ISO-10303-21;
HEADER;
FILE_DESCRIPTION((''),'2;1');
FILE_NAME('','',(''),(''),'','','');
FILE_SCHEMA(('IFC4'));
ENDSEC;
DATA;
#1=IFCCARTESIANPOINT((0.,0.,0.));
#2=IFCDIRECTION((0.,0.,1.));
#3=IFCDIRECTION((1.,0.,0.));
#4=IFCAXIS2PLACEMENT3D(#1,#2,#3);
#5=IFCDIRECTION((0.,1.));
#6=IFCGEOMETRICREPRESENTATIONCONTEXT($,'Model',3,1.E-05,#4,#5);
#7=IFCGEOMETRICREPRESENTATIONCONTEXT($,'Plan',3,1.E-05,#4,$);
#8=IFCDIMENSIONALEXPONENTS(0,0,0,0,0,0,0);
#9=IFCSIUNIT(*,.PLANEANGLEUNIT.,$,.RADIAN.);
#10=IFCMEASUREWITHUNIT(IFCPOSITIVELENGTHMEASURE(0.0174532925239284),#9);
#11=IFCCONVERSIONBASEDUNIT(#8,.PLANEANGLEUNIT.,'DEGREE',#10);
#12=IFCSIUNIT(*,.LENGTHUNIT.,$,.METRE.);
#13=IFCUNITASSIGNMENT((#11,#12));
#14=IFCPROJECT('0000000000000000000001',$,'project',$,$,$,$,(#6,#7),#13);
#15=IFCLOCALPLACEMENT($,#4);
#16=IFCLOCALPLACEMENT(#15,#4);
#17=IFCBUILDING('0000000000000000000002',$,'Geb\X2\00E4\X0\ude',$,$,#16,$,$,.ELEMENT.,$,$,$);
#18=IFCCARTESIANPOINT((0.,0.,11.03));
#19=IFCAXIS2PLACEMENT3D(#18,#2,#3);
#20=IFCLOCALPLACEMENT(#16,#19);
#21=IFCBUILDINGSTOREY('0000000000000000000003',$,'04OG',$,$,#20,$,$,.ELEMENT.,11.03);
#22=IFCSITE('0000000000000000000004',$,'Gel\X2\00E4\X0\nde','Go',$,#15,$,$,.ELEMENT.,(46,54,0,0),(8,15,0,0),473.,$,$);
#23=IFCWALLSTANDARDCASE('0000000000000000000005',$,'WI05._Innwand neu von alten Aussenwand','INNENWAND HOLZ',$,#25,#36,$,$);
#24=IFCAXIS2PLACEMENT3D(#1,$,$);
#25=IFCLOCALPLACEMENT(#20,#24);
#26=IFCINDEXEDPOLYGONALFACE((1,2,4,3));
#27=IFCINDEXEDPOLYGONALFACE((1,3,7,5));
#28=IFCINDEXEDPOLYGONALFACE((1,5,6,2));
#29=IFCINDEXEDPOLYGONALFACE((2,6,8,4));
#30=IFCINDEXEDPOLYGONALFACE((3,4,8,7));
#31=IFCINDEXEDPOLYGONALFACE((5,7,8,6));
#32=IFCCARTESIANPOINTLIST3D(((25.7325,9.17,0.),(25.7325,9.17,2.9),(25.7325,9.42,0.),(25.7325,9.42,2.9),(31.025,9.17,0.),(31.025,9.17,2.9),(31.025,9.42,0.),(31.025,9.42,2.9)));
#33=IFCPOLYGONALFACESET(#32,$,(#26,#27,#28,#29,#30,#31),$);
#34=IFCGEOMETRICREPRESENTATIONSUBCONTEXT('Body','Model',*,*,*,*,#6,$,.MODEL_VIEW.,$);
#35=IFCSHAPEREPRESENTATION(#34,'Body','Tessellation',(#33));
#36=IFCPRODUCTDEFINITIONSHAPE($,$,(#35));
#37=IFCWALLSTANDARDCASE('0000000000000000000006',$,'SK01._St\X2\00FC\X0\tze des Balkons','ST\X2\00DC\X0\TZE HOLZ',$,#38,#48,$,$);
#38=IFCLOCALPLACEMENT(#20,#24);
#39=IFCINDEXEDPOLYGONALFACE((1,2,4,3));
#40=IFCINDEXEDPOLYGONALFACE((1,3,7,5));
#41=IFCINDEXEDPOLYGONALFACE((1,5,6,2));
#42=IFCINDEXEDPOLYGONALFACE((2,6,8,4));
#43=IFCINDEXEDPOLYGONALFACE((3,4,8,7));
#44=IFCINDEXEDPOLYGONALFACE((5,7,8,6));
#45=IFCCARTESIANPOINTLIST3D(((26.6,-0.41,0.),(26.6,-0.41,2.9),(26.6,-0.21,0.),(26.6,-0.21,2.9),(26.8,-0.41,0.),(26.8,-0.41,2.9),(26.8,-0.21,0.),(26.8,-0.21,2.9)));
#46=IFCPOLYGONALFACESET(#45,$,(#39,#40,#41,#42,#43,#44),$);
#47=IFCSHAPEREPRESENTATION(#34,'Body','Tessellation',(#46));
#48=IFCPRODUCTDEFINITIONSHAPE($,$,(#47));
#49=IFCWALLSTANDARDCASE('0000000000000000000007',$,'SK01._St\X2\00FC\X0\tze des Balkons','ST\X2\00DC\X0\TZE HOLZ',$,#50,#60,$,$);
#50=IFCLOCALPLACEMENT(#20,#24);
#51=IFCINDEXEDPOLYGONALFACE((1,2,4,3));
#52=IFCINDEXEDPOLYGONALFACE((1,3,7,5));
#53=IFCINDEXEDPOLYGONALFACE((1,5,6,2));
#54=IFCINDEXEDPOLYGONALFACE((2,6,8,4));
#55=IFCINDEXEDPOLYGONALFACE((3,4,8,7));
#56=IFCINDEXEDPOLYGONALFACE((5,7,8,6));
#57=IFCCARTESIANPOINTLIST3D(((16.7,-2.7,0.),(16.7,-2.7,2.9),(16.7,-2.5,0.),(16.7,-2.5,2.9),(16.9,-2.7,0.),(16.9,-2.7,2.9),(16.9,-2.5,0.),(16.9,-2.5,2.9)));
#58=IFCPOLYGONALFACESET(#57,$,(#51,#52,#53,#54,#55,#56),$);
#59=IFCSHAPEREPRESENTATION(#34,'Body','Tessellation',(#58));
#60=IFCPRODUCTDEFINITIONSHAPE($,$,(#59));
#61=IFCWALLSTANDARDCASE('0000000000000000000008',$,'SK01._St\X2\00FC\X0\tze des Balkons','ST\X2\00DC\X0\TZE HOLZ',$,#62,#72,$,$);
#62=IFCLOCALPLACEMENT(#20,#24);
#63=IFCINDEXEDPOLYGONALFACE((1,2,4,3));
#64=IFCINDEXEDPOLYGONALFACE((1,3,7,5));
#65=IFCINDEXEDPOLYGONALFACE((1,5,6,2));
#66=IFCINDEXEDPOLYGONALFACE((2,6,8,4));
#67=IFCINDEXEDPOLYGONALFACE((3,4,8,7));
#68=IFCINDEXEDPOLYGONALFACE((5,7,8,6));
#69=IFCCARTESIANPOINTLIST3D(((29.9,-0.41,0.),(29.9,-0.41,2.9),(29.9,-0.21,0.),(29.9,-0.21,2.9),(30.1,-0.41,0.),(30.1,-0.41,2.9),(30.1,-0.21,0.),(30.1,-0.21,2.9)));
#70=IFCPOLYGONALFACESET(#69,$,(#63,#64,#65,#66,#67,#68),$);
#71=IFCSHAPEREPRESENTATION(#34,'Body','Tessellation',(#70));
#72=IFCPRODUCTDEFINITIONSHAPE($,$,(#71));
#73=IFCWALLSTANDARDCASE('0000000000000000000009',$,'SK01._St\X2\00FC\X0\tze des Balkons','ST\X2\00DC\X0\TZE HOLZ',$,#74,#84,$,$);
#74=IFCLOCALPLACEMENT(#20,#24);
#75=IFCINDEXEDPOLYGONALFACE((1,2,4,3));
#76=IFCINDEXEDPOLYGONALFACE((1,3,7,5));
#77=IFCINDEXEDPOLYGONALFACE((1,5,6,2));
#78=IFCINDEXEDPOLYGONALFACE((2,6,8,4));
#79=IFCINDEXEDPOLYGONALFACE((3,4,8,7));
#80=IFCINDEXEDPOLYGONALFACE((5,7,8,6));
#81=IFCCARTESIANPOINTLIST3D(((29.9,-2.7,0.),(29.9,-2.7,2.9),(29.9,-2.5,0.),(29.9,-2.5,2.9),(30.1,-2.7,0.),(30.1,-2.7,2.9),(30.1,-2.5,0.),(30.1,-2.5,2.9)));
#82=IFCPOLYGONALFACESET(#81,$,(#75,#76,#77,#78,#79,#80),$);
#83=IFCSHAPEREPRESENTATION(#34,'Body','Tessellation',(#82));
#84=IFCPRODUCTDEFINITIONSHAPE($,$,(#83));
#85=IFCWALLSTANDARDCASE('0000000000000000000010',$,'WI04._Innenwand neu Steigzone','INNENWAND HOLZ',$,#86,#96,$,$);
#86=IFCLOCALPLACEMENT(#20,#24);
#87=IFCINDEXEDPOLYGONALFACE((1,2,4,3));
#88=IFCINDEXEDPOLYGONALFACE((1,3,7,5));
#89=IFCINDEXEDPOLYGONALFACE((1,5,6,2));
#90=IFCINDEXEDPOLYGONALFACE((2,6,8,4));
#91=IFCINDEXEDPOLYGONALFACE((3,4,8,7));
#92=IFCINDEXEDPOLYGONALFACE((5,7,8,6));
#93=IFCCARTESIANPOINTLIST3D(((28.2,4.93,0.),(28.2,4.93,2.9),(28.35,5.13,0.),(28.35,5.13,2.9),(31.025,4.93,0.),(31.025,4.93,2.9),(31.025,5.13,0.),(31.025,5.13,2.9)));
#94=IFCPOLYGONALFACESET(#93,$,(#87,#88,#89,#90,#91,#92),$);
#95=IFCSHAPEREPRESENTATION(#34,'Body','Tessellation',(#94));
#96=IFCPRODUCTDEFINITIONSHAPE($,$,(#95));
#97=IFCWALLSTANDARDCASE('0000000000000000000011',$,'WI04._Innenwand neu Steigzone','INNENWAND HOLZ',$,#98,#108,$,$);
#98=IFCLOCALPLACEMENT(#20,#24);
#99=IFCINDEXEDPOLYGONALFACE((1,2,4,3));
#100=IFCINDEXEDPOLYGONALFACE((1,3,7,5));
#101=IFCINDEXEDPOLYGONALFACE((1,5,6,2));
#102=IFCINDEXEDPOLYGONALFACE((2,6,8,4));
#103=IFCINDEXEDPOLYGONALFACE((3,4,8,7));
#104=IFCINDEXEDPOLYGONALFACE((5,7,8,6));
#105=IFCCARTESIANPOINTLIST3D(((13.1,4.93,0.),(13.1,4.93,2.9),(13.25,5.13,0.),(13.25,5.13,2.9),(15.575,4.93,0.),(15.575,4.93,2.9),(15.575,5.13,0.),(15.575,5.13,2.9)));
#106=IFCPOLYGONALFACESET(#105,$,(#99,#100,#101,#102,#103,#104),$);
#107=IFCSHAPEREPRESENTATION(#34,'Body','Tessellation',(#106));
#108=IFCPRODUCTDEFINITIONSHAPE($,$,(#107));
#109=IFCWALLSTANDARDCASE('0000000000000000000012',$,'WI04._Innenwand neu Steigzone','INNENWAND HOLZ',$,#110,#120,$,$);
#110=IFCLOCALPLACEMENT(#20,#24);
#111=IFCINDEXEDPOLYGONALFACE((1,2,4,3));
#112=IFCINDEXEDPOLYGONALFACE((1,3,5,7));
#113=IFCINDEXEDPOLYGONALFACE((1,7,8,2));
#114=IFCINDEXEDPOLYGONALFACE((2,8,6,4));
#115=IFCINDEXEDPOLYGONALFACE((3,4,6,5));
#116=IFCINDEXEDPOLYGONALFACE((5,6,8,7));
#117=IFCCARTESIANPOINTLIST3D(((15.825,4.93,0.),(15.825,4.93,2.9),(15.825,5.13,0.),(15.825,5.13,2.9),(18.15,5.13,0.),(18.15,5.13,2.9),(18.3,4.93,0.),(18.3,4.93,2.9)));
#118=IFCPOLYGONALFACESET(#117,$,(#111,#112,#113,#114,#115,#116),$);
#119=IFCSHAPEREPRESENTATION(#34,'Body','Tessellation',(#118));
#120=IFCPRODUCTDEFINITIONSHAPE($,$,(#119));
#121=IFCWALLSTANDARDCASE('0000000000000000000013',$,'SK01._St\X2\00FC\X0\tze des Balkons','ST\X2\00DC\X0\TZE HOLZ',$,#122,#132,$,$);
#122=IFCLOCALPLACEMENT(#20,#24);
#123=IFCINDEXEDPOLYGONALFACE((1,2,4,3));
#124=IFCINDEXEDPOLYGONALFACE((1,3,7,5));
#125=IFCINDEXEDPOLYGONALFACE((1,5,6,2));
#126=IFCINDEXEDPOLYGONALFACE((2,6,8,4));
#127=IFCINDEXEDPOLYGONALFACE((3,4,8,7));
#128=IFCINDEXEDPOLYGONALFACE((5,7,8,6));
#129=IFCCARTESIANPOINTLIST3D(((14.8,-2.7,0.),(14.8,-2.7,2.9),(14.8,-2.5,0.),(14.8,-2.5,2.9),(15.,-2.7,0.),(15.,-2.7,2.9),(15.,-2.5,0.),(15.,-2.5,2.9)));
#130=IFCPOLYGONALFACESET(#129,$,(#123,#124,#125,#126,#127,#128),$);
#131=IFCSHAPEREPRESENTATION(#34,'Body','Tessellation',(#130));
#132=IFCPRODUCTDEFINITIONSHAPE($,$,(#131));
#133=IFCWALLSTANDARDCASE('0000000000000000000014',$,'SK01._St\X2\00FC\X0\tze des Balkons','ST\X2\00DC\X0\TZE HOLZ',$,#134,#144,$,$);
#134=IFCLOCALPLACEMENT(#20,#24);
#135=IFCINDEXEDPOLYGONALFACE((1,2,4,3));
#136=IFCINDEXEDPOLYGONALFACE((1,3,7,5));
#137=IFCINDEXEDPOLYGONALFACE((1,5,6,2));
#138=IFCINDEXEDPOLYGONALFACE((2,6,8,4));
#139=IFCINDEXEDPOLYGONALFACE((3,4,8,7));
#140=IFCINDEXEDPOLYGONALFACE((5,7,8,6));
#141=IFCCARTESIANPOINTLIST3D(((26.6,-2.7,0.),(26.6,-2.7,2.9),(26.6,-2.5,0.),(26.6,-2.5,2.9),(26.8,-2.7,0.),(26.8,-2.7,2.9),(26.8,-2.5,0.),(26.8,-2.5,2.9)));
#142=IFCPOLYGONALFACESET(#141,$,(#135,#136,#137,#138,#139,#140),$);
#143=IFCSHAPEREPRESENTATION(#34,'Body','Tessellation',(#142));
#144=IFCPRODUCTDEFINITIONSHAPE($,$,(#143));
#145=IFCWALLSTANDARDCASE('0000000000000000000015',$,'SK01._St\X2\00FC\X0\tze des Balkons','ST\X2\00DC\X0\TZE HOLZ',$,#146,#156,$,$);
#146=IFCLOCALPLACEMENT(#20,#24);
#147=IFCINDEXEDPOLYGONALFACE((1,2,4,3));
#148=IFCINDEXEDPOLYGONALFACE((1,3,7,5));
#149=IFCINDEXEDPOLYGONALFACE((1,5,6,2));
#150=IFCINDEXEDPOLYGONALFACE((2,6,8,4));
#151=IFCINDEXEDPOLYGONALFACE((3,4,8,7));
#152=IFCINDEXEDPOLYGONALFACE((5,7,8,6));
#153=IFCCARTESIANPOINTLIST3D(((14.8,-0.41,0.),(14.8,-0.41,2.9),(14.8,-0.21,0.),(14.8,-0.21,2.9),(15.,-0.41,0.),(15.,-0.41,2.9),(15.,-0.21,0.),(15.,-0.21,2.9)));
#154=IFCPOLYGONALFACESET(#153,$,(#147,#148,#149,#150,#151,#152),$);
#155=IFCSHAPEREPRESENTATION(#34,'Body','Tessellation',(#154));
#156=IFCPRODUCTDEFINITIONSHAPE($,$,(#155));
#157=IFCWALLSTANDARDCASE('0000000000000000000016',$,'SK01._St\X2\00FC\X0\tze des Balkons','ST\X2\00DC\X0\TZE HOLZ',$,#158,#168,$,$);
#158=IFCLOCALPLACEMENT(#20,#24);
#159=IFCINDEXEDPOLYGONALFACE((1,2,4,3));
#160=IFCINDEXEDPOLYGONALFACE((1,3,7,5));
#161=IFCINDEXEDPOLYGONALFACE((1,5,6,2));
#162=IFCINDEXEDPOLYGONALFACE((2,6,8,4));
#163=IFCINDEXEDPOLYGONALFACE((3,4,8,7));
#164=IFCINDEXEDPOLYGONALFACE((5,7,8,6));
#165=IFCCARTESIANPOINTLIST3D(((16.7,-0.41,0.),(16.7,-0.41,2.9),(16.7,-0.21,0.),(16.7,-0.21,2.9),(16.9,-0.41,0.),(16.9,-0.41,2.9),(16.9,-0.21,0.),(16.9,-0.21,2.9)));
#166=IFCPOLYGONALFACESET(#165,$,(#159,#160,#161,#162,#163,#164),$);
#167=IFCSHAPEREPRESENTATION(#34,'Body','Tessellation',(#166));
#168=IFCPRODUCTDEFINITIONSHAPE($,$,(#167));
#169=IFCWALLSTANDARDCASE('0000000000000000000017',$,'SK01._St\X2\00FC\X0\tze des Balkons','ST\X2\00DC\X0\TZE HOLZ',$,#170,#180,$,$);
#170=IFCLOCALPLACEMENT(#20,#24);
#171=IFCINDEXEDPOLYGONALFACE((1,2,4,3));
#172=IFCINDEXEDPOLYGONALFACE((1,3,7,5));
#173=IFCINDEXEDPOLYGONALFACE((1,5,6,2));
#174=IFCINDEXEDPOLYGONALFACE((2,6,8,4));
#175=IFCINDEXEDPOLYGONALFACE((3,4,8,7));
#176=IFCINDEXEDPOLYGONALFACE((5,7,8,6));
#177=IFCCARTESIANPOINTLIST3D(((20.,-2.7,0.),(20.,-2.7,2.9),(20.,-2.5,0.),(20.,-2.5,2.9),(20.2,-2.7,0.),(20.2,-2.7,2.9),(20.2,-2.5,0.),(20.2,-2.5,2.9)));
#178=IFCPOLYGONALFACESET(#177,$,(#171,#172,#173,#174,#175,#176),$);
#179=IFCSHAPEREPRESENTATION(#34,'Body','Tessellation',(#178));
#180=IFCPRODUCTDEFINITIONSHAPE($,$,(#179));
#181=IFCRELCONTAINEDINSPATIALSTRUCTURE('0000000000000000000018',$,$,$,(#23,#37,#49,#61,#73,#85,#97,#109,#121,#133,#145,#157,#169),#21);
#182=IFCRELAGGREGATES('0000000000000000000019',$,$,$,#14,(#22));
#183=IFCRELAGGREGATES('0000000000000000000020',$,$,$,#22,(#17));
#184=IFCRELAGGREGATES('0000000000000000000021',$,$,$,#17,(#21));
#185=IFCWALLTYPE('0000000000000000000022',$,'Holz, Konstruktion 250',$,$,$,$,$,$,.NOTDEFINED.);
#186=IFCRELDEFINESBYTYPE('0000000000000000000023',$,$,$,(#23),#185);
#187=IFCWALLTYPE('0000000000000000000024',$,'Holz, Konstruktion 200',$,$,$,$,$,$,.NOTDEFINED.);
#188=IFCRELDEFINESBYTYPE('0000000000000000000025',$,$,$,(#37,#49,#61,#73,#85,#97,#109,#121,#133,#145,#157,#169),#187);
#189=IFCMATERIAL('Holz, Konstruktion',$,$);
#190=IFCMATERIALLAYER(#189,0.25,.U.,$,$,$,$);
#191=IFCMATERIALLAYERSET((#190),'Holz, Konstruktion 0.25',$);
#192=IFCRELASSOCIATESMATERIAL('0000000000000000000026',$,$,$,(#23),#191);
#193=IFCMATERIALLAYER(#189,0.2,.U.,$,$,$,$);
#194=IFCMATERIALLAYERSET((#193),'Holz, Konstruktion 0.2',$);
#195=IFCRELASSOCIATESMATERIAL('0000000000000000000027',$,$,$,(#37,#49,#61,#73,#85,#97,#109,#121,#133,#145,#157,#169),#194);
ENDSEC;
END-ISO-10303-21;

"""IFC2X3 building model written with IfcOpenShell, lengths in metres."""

from ifc_helpers import new_model, entity, si_unit, converted_unit, direction, frame, origin_with_axes, place, context, subcontext, project, spatial, polyline, outline, extrude, material, layer, layer_set, layer_usage, type_object, element, save


model = new_model("IFC2X3")

# Units and contexts
model_context = context("Model", 3, precision=1e-05, world=origin_with_axes(), true_north=direction((0.0, 1.0)))
plan_context = context("Plan", 3, precision=1e-05, world=origin_with_axes())
body_context = subcontext(model_context, "Body", "Model", "MODEL_VIEW")
ifc_project = project(units=[converted_unit("PLANEANGLEUNIT", "DEGREE", entity("IfcPositiveLengthMeasure", 0.0174532925239284), si_unit("PLANEANGLEUNIT", "RADIAN"), dimensions=[0, 0, 0, 0, 0, 0, 0]), si_unit("LENGTHUNIT", "METRE")], contexts=[model_context, plan_context])

# Site, building, storey
site_placement = place(None, origin_with_axes())
site = spatial("IfcSite", under=ifc_project, at=site_placement, Name="Gelände", Description="Go", CompositionType="ELEMENT", RefLatitude=(46, 54, 0, 0), RefLongitude=(8, 15, 0, 0), RefElevation=473.0)
building_placement = place(site_placement, origin_with_axes())
building = spatial("IfcBuilding", under=site, at=building_placement, Name="Gebäude", CompositionType="ELEMENT")
storey_placement = place(building_placement, frame((0.0, 0.0, 11.03), z_axis=(0.0, 0.0, 1.0), x_axis=(1.0, 0.0, 0.0)))
storey = spatial("IfcBuildingStorey", under=building, at=storey_placement, Name="04OG", CompositionType="ELEMENT", Elevation=11.03)

# Shared definitions
ifc_material_1 = material(Name="Holz, Konstruktion")

# Walls
ifc_layer_1 = layer(ifc_material_1, 0.25, ventilated="UNKNOWN")
ifc_layer_set_1 = layer_set([ifc_layer_1], Name="Holz, Konstruktion 0.25")
wall_type_1 = type_object("IfcWallType", Name="Holz, Konstruktion 250", PredefinedType="NOTDEFINED")
ifc_layer_usage_1 = layer_usage(ifc_layer_set_1, "AXIS2", "NEGATIVE", 0.0)
wall_1_placement = place(storey_placement, frame((25.7325, 9.42, 0.0), z_axis=(0.0, 0.0, 1.0), x_axis=(1.0, 0.0, 0.0)))
element("IfcWallStandardCase", 1, at=wall_1_placement, inside=storey, type_object=wall_type_1, material=ifc_layer_usage_1, Name="WI05._Innwand neu von alten Aussenwand", Description="INNENWAND HOLZ", context=body_context, shape_type="SweptSolid", body=[
    extrude(outline(polyline([(0.0, -0.25), (5.2925, -0.25), (5.2925, 0.0), (0.0, 0.0), (0.0, -0.25)])), origin_with_axes(), (0.0, 0.0, 1.0), 2.9),
])
ifc_layer_2 = layer(ifc_material_1, 0.2, ventilated="UNKNOWN")
ifc_layer_set_2 = layer_set([ifc_layer_2], Name="Holz, Konstruktion 0.2")
ifc_layer_usage_2 = layer_usage(ifc_layer_set_2, "AXIS2", "NEGATIVE", 0.0)
wall_type_2 = type_object("IfcWallType", Name="Holz, Konstruktion 200", PredefinedType="NOTDEFINED")
wall_2_placement = place(storey_placement, frame((26.6, -0.41, 0.0), z_axis=(0.0, 0.0, 1.0), x_axis=(0.0, 1.0, 0.0)))
element("IfcWallStandardCase", 2, at=wall_2_placement, inside=storey, type_object=wall_type_2, material=ifc_layer_usage_2, Name="SK01._Stütze des Balkons", Description="STÜTZE HOLZ", context=body_context, shape_type="SweptSolid", body=[
    extrude(outline(polyline([(0.0, -0.2), (0.2, -0.2), (0.2, 0.0), (0.0, 0.0), (0.0, -0.2)])), origin_with_axes(), (0.0, 0.0, 1.0), 2.9),
])
ifc_layer_usage_3 = layer_usage(ifc_layer_set_2, "AXIS2", "NEGATIVE", 0.0)
wall_3_placement = place(storey_placement, frame((16.7, -2.7, 0.0), z_axis=(0.0, 0.0, 1.0), x_axis=(0.0, 1.0, 0.0)))
element("IfcWallStandardCase", 3, at=wall_3_placement, inside=storey, type_object=wall_type_2, material=ifc_layer_usage_3, Name="SK01._Stütze des Balkons", Description="STÜTZE HOLZ", context=body_context, shape_type="SweptSolid", body=[
    extrude(outline(polyline([(0.0, -0.2), (0.2, -0.2), (0.2, 0.0), (0.0, 0.0), (0.0, -0.2)])), origin_with_axes(), (0.0, 0.0, 1.0), 2.9),
])
ifc_layer_usage_4 = layer_usage(ifc_layer_set_2, "AXIS2", "POSITIVE", 0.0)
wall_4_placement = place(storey_placement, frame((30.1, -0.41, 0.0), z_axis=(0.0, 0.0, 1.0), x_axis=(0.0, 1.0, 0.0)))
element("IfcWallStandardCase", 4, at=wall_4_placement, inside=storey, type_object=wall_type_2, material=ifc_layer_usage_4, Name="SK01._Stütze des Balkons", Description="STÜTZE HOLZ", context=body_context, shape_type="SweptSolid", body=[
    extrude(outline(polyline([(0.0, 0.0), (0.2, 0.0), (0.2, 0.2), (0.0, 0.2), (0.0, 0.0)])), origin_with_axes(), (0.0, 0.0, 1.0), 2.9),
])
ifc_layer_usage_5 = layer_usage(ifc_layer_set_2, "AXIS2", "POSITIVE", 0.0)
wall_5_placement = place(storey_placement, frame((30.1, -2.7, 0.0), z_axis=(0.0, 0.0, 1.0), x_axis=(0.0, 1.0, 0.0)))
element("IfcWallStandardCase", 5, at=wall_5_placement, inside=storey, type_object=wall_type_2, material=ifc_layer_usage_5, Name="SK01._Stütze des Balkons", Description="STÜTZE HOLZ", context=body_context, shape_type="SweptSolid", body=[
    extrude(outline(polyline([(0.0, 0.0), (0.2, 0.0), (0.2, 0.2), (0.0, 0.2), (0.0, 0.0)])), origin_with_axes(), (0.0, 0.0, 1.0), 2.9),
])
ifc_layer_usage_6 = layer_usage(ifc_layer_set_2, "AXIS2", "POSITIVE", 0.0)
wall_6_placement = place(storey_placement, frame((28.2, 4.93, 0.0), z_axis=(0.0, 0.0, 1.0), x_axis=(1.0, 0.0, 0.0)))
element("IfcWallStandardCase", 6, at=wall_6_placement, inside=storey, type_object=wall_type_2, material=ifc_layer_usage_6, Name="WI04._Innenwand neu Steigzone", Description="INNENWAND HOLZ", context=body_context, shape_type="SweptSolid", body=[
    extrude(outline(polyline([(0.0, 0.0), (2.825, 0.0), (2.825, 0.2), (0.15, 0.2), (0.0, 0.0)])), origin_with_axes(), (0.0, 0.0, 1.0), 2.9),
])
ifc_layer_usage_7 = layer_usage(ifc_layer_set_2, "AXIS2", "POSITIVE", 0.0)
wall_7_placement = place(storey_placement, frame((13.1, 4.93, 0.0), z_axis=(0.0, 0.0, 1.0), x_axis=(1.0, 0.0, 0.0)))
element("IfcWallStandardCase", 7, at=wall_7_placement, inside=storey, type_object=wall_type_2, material=ifc_layer_usage_7, Name="WI04._Innenwand neu Steigzone", Description="INNENWAND HOLZ", context=body_context, shape_type="SweptSolid", body=[
    extrude(outline(polyline([(0.0, 0.0), (2.475, 0.0), (2.475, 0.2), (0.15, 0.2), (0.0, 0.0)])), origin_with_axes(), (0.0, 0.0, 1.0), 2.9),
])
ifc_layer_usage_8 = layer_usage(ifc_layer_set_2, "AXIS2", "NEGATIVE", 0.0)
wall_8_placement = place(storey_placement, frame((18.3, 4.93, 0.0), z_axis=(0.0, 0.0, 1.0), x_axis=(-1.0, 0.0, 0.0)))
element("IfcWallStandardCase", 8, at=wall_8_placement, inside=storey, type_object=wall_type_2, material=ifc_layer_usage_8, Name="WI04._Innenwand neu Steigzone", Description="INNENWAND HOLZ", context=body_context, shape_type="SweptSolid", body=[
    extrude(outline(polyline([(0.15, -0.2), (2.475, -0.2), (2.475, 0.0), (0.0, 0.0), (0.15, -0.2)])), origin_with_axes(), (0.0, 0.0, 1.0), 2.9),
])
ifc_layer_usage_9 = layer_usage(ifc_layer_set_2, "AXIS2", "POSITIVE", 0.0)
wall_9_placement = place(storey_placement, frame((15.0, -2.7, 0.0), z_axis=(0.0, 0.0, 1.0), x_axis=(0.0, 1.0, 0.0)))
element("IfcWallStandardCase", 9, at=wall_9_placement, inside=storey, type_object=wall_type_2, material=ifc_layer_usage_9, Name="SK01._Stütze des Balkons", Description="STÜTZE HOLZ", context=body_context, shape_type="SweptSolid", body=[
    extrude(outline(polyline([(0.0, 0.0), (0.2, 0.0), (0.2, 0.2), (0.0, 0.2), (0.0, 0.0)])), origin_with_axes(), (0.0, 0.0, 1.0), 2.9),
])
ifc_layer_usage_10 = layer_usage(ifc_layer_set_2, "AXIS2", "NEGATIVE", 0.0)
wall_10_placement = place(storey_placement, frame((26.6, -2.7, 0.0), z_axis=(0.0, 0.0, 1.0), x_axis=(0.0, 1.0, 0.0)))
element("IfcWallStandardCase", 10, at=wall_10_placement, inside=storey, type_object=wall_type_2, material=ifc_layer_usage_10, Name="SK01._Stütze des Balkons", Description="STÜTZE HOLZ", context=body_context, shape_type="SweptSolid", body=[
    extrude(outline(polyline([(0.0, -0.2), (0.2, -0.2), (0.2, 0.0), (0.0, 0.0), (0.0, -0.2)])), origin_with_axes(), (0.0, 0.0, 1.0), 2.9),
])
ifc_layer_usage_11 = layer_usage(ifc_layer_set_2, "AXIS2", "POSITIVE", 0.0)
wall_11_placement = place(storey_placement, frame((15.0, -0.41, 0.0), z_axis=(0.0, 0.0, 1.0), x_axis=(0.0, 1.0, 0.0)))
element("IfcWallStandardCase", 11, at=wall_11_placement, inside=storey, type_object=wall_type_2, material=ifc_layer_usage_11, Name="SK01._Stütze des Balkons", Description="STÜTZE HOLZ", context=body_context, shape_type="SweptSolid", body=[
    extrude(outline(polyline([(0.0, 0.0), (0.2, 0.0), (0.2, 0.2), (0.0, 0.2), (0.0, 0.0)])), origin_with_axes(), (0.0, 0.0, 1.0), 2.9),
])
ifc_layer_usage_12 = layer_usage(ifc_layer_set_2, "AXIS2", "NEGATIVE", 0.0)
wall_12_placement = place(storey_placement, frame((16.7, -0.41, 0.0), z_axis=(0.0, 0.0, 1.0), x_axis=(0.0, 1.0, 0.0)))
element("IfcWallStandardCase", 12, at=wall_12_placement, inside=storey, type_object=wall_type_2, material=ifc_layer_usage_12, Name="SK01._Stütze des Balkons", Description="STÜTZE HOLZ", context=body_context, shape_type="SweptSolid", body=[
    extrude(outline(polyline([(0.0, -0.2), (0.2, -0.2), (0.2, 0.0), (0.0, 0.0), (0.0, -0.2)])), origin_with_axes(), (0.0, 0.0, 1.0), 2.9),
])
ifc_layer_usage_13 = layer_usage(ifc_layer_set_2, "AXIS2", "POSITIVE", 0.0)
wall_13_placement = place(storey_placement, frame((20.2, -2.7, 0.0), z_axis=(0.0, 0.0, 1.0), x_axis=(0.0, 1.0, 0.0)))
element("IfcWallStandardCase", 13, at=wall_13_placement, inside=storey, type_object=wall_type_2, material=ifc_layer_usage_13, Name="SK01._Stütze des Balkons", Description="STÜTZE HOLZ", context=body_context, shape_type="SweptSolid", body=[
    extrude(outline(polyline([(0.0, 0.0), (0.2, 0.0), (0.2, 0.2), (0.0, 0.2), (0.0, 0.0)])), origin_with_axes(), (0.0, 0.0, 1.0), 2.9),
])

save(model, "model.ifc")
